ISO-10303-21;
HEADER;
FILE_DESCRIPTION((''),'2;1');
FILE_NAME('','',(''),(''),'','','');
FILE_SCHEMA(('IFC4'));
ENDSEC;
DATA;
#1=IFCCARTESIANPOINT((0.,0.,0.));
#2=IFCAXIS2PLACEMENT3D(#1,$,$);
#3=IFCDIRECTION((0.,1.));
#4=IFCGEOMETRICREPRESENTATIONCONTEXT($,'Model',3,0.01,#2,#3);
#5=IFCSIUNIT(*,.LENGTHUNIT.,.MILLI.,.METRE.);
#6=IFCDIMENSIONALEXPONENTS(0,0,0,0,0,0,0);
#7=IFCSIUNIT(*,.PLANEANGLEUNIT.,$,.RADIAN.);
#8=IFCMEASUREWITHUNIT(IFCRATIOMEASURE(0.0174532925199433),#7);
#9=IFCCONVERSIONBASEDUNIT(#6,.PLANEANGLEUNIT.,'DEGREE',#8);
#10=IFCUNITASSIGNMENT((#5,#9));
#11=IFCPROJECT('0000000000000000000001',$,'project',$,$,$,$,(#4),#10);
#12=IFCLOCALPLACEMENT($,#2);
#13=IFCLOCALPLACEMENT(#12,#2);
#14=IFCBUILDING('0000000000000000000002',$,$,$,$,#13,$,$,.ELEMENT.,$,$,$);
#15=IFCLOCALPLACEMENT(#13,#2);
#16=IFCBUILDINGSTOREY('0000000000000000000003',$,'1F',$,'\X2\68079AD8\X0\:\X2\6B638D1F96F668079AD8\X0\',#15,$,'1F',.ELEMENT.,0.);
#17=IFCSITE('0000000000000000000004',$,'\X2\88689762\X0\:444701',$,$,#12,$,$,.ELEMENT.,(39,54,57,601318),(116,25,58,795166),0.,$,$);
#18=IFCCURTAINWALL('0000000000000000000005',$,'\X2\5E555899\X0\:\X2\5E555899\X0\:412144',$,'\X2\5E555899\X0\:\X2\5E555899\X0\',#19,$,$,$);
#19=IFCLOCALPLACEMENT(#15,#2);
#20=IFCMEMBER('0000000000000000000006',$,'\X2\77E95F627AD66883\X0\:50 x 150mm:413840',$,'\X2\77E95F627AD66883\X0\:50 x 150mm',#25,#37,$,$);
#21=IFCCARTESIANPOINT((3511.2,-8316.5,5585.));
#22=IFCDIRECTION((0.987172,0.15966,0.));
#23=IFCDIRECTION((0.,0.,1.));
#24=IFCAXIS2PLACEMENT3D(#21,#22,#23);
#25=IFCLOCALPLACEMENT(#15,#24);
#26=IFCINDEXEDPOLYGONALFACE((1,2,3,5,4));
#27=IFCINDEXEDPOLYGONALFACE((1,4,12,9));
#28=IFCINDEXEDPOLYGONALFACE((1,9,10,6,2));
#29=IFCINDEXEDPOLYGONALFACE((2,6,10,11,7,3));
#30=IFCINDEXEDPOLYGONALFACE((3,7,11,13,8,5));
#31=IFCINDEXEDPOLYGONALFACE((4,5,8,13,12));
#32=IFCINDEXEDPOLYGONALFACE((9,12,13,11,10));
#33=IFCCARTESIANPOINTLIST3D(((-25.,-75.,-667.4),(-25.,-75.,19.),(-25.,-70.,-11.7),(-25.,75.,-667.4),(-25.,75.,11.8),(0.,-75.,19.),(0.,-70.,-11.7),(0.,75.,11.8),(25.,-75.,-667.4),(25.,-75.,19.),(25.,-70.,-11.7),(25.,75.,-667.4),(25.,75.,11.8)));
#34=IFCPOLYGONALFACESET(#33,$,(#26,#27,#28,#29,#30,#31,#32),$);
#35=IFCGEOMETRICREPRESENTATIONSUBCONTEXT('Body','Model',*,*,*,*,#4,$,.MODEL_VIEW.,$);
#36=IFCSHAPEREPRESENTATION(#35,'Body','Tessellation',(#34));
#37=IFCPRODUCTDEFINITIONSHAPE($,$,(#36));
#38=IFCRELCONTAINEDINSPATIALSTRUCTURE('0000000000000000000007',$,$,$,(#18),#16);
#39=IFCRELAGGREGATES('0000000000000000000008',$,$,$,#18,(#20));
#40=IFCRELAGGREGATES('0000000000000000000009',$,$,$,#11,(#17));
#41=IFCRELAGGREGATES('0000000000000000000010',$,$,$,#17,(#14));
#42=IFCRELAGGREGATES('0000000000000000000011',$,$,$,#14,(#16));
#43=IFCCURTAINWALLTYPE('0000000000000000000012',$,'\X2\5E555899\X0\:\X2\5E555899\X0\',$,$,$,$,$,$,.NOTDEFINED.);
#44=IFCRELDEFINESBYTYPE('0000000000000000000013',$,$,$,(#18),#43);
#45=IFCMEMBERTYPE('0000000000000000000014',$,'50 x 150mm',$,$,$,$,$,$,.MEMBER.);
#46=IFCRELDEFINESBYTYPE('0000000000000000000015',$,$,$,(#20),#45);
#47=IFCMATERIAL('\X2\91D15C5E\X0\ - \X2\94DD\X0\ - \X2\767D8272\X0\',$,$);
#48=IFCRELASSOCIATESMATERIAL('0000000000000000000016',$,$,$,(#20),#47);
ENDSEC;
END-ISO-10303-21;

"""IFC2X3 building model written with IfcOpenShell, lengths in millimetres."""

from ifc_helpers import new_model, entity, si_unit, converted_unit, direction, frame, origin, origin_2d_with_axis, place, context, subcontext, project, spatial, polyline, rectangle, extrude, clip, bounded_halfspace, source, transform, mapped, material, type_object, type_shapes, element, aggregate, save


model = new_model("IFC2X3")

# Units and contexts
model_context = context("Model", 3, precision=0.01, world=origin(), true_north=direction((0.0, 1.0)))
body_context = subcontext(model_context, "Body", "Model", "MODEL_VIEW")
ifc_project = project(units=[si_unit("LENGTHUNIT", "METRE", prefix="MILLI"), converted_unit("PLANEANGLEUNIT", "DEGREE", entity("IfcRatioMeasure", 0.0174532925199433), si_unit("PLANEANGLEUNIT", "RADIAN"), dimensions=[0, 0, 0, 0, 0, 0, 0])], contexts=[model_context])

# Site, building, storey
site_placement = place(None, origin())
site = spatial("IfcSite", under=ifc_project, at=site_placement, Name="表面:444701", CompositionType="ELEMENT", RefLatitude=(39, 54, 57, 601318), RefLongitude=(116, 25, 58, 795166), RefElevation=0.0)
building_placement = place(site_placement, origin())
building = spatial("IfcBuilding", under=site, at=building_placement, CompositionType="ELEMENT")
storey_placement = place(building_placement, origin())
storey = spatial("IfcBuildingStorey", under=building, at=storey_placement, Name="1F", ObjectType="标高:正负零标高", LongName="1F", CompositionType="ELEMENT", Elevation=0.0)

# Curtain wall, member
curtain_wall_type = type_object("IfcCurtainWallType", Name="幕墙:幕墙", PredefinedType="NOTDEFINED")
curtain_wall_placement = place(storey_placement, origin())
curtain_wall = element("IfcCurtainWall", 1, at=curtain_wall_placement, inside=storey, type_object=curtain_wall_type, Name="幕墙:幕墙:412144", ObjectType="幕墙:幕墙")
ifc_material_1 = material(Name="金属 - 铝 - 白色")
member_type_1 = type_object("IfcMemberType", Name="50 x 150mm", PredefinedType="MEMBER")
shared_shape_1 = source(origin(), body_context, "Body", "Clipping", [
    clip(clip(clip(clip(extrude(rectangle(XDim=150.0, YDim=50.0, at=origin_2d_with_axis()), frame((0.0, 0.0, -667.4), z_axis=(0.0, 0.0, 1.0), x_axis=(0.0, -1.0, 0.0)), (0.0, 0.0, 1.0), 686.4), bounded_halfspace(frame((-1390.0, -70.0, -11.7), z_axis=(0.0, 0.987172, 0.15966), x_axis=(1.0, 0.0, 0.0)), False, frame((0.0, 0.0, -667.4), z_axis=(0.0, 0.0, 1.0), x_axis=(0.0, -1.0, 0.0)), polyline([(70.0, -25.0), (75.0, -25.0), (75.0, 0.0), (70.0, 0.0), (70.0, -25.0)]))), bounded_halfspace(frame((0.0, -70.0, -11.7), z_axis=(0.0, 0.987172, 0.15966), x_axis=(1.0, 0.0, 0.0)), False, frame((0.0, 0.0, -667.4), z_axis=(0.0, 0.0, 1.0), x_axis=(0.0, -1.0, 0.0)), polyline([(75.0, 0.0), (75.0, 25.0), (70.0, 25.0), (70.0, 0.0), (75.0, 0.0)]))), bounded_halfspace(frame((-1390.0, 78.0, 12.3), z_axis=(0.0, -0.15966, 0.987172), x_axis=(1.0, 0.0, 0.0)), False, frame((0.0, 0.0, -667.4), z_axis=(0.0, 0.0, 1.0), x_axis=(0.0, -1.0, 0.0)), polyline([(-75.0, 0.0), (-75.0, -25.0), (70.0, -25.0), (70.0, 0.0), (-75.0, 0.0)]))), bounded_halfspace(frame((0.0, 78.0, 12.3), z_axis=(0.0, -0.15966, 0.987172), x_axis=(1.0, 0.0, 0.0)), False, frame((0.0, 0.0, -667.4), z_axis=(0.0, 0.0, 1.0), x_axis=(0.0, -1.0, 0.0)), polyline([(-75.0, 25.0), (-75.0, 0.0), (70.0, 0.0), (70.0, 25.0), (-75.0, 25.0)]))),
])
type_shapes(member_type_1, [shared_shape_1])
member_1_placement = place(storey_placement, frame((3511.2, -8316.5, 5585.0), z_axis=(0.987172, 0.15966, 0.0), x_axis=(0.0, 0.0, 1.0)))
member_1 = element("IfcMember", 2, at=member_1_placement, type_object=member_type_1, material=ifc_material_1, Name="矩形竖梃:50 x 150mm:413840", ObjectType="矩形竖梃:50 x 150mm", context=body_context, shape_type="MappedRepresentation", body=[
    mapped(shared_shape_1, transform((0.0, 0.0, 0.0), scale=1.0)),
])
aggregate(curtain_wall, [member_1])

save(model, "model.ifc")
